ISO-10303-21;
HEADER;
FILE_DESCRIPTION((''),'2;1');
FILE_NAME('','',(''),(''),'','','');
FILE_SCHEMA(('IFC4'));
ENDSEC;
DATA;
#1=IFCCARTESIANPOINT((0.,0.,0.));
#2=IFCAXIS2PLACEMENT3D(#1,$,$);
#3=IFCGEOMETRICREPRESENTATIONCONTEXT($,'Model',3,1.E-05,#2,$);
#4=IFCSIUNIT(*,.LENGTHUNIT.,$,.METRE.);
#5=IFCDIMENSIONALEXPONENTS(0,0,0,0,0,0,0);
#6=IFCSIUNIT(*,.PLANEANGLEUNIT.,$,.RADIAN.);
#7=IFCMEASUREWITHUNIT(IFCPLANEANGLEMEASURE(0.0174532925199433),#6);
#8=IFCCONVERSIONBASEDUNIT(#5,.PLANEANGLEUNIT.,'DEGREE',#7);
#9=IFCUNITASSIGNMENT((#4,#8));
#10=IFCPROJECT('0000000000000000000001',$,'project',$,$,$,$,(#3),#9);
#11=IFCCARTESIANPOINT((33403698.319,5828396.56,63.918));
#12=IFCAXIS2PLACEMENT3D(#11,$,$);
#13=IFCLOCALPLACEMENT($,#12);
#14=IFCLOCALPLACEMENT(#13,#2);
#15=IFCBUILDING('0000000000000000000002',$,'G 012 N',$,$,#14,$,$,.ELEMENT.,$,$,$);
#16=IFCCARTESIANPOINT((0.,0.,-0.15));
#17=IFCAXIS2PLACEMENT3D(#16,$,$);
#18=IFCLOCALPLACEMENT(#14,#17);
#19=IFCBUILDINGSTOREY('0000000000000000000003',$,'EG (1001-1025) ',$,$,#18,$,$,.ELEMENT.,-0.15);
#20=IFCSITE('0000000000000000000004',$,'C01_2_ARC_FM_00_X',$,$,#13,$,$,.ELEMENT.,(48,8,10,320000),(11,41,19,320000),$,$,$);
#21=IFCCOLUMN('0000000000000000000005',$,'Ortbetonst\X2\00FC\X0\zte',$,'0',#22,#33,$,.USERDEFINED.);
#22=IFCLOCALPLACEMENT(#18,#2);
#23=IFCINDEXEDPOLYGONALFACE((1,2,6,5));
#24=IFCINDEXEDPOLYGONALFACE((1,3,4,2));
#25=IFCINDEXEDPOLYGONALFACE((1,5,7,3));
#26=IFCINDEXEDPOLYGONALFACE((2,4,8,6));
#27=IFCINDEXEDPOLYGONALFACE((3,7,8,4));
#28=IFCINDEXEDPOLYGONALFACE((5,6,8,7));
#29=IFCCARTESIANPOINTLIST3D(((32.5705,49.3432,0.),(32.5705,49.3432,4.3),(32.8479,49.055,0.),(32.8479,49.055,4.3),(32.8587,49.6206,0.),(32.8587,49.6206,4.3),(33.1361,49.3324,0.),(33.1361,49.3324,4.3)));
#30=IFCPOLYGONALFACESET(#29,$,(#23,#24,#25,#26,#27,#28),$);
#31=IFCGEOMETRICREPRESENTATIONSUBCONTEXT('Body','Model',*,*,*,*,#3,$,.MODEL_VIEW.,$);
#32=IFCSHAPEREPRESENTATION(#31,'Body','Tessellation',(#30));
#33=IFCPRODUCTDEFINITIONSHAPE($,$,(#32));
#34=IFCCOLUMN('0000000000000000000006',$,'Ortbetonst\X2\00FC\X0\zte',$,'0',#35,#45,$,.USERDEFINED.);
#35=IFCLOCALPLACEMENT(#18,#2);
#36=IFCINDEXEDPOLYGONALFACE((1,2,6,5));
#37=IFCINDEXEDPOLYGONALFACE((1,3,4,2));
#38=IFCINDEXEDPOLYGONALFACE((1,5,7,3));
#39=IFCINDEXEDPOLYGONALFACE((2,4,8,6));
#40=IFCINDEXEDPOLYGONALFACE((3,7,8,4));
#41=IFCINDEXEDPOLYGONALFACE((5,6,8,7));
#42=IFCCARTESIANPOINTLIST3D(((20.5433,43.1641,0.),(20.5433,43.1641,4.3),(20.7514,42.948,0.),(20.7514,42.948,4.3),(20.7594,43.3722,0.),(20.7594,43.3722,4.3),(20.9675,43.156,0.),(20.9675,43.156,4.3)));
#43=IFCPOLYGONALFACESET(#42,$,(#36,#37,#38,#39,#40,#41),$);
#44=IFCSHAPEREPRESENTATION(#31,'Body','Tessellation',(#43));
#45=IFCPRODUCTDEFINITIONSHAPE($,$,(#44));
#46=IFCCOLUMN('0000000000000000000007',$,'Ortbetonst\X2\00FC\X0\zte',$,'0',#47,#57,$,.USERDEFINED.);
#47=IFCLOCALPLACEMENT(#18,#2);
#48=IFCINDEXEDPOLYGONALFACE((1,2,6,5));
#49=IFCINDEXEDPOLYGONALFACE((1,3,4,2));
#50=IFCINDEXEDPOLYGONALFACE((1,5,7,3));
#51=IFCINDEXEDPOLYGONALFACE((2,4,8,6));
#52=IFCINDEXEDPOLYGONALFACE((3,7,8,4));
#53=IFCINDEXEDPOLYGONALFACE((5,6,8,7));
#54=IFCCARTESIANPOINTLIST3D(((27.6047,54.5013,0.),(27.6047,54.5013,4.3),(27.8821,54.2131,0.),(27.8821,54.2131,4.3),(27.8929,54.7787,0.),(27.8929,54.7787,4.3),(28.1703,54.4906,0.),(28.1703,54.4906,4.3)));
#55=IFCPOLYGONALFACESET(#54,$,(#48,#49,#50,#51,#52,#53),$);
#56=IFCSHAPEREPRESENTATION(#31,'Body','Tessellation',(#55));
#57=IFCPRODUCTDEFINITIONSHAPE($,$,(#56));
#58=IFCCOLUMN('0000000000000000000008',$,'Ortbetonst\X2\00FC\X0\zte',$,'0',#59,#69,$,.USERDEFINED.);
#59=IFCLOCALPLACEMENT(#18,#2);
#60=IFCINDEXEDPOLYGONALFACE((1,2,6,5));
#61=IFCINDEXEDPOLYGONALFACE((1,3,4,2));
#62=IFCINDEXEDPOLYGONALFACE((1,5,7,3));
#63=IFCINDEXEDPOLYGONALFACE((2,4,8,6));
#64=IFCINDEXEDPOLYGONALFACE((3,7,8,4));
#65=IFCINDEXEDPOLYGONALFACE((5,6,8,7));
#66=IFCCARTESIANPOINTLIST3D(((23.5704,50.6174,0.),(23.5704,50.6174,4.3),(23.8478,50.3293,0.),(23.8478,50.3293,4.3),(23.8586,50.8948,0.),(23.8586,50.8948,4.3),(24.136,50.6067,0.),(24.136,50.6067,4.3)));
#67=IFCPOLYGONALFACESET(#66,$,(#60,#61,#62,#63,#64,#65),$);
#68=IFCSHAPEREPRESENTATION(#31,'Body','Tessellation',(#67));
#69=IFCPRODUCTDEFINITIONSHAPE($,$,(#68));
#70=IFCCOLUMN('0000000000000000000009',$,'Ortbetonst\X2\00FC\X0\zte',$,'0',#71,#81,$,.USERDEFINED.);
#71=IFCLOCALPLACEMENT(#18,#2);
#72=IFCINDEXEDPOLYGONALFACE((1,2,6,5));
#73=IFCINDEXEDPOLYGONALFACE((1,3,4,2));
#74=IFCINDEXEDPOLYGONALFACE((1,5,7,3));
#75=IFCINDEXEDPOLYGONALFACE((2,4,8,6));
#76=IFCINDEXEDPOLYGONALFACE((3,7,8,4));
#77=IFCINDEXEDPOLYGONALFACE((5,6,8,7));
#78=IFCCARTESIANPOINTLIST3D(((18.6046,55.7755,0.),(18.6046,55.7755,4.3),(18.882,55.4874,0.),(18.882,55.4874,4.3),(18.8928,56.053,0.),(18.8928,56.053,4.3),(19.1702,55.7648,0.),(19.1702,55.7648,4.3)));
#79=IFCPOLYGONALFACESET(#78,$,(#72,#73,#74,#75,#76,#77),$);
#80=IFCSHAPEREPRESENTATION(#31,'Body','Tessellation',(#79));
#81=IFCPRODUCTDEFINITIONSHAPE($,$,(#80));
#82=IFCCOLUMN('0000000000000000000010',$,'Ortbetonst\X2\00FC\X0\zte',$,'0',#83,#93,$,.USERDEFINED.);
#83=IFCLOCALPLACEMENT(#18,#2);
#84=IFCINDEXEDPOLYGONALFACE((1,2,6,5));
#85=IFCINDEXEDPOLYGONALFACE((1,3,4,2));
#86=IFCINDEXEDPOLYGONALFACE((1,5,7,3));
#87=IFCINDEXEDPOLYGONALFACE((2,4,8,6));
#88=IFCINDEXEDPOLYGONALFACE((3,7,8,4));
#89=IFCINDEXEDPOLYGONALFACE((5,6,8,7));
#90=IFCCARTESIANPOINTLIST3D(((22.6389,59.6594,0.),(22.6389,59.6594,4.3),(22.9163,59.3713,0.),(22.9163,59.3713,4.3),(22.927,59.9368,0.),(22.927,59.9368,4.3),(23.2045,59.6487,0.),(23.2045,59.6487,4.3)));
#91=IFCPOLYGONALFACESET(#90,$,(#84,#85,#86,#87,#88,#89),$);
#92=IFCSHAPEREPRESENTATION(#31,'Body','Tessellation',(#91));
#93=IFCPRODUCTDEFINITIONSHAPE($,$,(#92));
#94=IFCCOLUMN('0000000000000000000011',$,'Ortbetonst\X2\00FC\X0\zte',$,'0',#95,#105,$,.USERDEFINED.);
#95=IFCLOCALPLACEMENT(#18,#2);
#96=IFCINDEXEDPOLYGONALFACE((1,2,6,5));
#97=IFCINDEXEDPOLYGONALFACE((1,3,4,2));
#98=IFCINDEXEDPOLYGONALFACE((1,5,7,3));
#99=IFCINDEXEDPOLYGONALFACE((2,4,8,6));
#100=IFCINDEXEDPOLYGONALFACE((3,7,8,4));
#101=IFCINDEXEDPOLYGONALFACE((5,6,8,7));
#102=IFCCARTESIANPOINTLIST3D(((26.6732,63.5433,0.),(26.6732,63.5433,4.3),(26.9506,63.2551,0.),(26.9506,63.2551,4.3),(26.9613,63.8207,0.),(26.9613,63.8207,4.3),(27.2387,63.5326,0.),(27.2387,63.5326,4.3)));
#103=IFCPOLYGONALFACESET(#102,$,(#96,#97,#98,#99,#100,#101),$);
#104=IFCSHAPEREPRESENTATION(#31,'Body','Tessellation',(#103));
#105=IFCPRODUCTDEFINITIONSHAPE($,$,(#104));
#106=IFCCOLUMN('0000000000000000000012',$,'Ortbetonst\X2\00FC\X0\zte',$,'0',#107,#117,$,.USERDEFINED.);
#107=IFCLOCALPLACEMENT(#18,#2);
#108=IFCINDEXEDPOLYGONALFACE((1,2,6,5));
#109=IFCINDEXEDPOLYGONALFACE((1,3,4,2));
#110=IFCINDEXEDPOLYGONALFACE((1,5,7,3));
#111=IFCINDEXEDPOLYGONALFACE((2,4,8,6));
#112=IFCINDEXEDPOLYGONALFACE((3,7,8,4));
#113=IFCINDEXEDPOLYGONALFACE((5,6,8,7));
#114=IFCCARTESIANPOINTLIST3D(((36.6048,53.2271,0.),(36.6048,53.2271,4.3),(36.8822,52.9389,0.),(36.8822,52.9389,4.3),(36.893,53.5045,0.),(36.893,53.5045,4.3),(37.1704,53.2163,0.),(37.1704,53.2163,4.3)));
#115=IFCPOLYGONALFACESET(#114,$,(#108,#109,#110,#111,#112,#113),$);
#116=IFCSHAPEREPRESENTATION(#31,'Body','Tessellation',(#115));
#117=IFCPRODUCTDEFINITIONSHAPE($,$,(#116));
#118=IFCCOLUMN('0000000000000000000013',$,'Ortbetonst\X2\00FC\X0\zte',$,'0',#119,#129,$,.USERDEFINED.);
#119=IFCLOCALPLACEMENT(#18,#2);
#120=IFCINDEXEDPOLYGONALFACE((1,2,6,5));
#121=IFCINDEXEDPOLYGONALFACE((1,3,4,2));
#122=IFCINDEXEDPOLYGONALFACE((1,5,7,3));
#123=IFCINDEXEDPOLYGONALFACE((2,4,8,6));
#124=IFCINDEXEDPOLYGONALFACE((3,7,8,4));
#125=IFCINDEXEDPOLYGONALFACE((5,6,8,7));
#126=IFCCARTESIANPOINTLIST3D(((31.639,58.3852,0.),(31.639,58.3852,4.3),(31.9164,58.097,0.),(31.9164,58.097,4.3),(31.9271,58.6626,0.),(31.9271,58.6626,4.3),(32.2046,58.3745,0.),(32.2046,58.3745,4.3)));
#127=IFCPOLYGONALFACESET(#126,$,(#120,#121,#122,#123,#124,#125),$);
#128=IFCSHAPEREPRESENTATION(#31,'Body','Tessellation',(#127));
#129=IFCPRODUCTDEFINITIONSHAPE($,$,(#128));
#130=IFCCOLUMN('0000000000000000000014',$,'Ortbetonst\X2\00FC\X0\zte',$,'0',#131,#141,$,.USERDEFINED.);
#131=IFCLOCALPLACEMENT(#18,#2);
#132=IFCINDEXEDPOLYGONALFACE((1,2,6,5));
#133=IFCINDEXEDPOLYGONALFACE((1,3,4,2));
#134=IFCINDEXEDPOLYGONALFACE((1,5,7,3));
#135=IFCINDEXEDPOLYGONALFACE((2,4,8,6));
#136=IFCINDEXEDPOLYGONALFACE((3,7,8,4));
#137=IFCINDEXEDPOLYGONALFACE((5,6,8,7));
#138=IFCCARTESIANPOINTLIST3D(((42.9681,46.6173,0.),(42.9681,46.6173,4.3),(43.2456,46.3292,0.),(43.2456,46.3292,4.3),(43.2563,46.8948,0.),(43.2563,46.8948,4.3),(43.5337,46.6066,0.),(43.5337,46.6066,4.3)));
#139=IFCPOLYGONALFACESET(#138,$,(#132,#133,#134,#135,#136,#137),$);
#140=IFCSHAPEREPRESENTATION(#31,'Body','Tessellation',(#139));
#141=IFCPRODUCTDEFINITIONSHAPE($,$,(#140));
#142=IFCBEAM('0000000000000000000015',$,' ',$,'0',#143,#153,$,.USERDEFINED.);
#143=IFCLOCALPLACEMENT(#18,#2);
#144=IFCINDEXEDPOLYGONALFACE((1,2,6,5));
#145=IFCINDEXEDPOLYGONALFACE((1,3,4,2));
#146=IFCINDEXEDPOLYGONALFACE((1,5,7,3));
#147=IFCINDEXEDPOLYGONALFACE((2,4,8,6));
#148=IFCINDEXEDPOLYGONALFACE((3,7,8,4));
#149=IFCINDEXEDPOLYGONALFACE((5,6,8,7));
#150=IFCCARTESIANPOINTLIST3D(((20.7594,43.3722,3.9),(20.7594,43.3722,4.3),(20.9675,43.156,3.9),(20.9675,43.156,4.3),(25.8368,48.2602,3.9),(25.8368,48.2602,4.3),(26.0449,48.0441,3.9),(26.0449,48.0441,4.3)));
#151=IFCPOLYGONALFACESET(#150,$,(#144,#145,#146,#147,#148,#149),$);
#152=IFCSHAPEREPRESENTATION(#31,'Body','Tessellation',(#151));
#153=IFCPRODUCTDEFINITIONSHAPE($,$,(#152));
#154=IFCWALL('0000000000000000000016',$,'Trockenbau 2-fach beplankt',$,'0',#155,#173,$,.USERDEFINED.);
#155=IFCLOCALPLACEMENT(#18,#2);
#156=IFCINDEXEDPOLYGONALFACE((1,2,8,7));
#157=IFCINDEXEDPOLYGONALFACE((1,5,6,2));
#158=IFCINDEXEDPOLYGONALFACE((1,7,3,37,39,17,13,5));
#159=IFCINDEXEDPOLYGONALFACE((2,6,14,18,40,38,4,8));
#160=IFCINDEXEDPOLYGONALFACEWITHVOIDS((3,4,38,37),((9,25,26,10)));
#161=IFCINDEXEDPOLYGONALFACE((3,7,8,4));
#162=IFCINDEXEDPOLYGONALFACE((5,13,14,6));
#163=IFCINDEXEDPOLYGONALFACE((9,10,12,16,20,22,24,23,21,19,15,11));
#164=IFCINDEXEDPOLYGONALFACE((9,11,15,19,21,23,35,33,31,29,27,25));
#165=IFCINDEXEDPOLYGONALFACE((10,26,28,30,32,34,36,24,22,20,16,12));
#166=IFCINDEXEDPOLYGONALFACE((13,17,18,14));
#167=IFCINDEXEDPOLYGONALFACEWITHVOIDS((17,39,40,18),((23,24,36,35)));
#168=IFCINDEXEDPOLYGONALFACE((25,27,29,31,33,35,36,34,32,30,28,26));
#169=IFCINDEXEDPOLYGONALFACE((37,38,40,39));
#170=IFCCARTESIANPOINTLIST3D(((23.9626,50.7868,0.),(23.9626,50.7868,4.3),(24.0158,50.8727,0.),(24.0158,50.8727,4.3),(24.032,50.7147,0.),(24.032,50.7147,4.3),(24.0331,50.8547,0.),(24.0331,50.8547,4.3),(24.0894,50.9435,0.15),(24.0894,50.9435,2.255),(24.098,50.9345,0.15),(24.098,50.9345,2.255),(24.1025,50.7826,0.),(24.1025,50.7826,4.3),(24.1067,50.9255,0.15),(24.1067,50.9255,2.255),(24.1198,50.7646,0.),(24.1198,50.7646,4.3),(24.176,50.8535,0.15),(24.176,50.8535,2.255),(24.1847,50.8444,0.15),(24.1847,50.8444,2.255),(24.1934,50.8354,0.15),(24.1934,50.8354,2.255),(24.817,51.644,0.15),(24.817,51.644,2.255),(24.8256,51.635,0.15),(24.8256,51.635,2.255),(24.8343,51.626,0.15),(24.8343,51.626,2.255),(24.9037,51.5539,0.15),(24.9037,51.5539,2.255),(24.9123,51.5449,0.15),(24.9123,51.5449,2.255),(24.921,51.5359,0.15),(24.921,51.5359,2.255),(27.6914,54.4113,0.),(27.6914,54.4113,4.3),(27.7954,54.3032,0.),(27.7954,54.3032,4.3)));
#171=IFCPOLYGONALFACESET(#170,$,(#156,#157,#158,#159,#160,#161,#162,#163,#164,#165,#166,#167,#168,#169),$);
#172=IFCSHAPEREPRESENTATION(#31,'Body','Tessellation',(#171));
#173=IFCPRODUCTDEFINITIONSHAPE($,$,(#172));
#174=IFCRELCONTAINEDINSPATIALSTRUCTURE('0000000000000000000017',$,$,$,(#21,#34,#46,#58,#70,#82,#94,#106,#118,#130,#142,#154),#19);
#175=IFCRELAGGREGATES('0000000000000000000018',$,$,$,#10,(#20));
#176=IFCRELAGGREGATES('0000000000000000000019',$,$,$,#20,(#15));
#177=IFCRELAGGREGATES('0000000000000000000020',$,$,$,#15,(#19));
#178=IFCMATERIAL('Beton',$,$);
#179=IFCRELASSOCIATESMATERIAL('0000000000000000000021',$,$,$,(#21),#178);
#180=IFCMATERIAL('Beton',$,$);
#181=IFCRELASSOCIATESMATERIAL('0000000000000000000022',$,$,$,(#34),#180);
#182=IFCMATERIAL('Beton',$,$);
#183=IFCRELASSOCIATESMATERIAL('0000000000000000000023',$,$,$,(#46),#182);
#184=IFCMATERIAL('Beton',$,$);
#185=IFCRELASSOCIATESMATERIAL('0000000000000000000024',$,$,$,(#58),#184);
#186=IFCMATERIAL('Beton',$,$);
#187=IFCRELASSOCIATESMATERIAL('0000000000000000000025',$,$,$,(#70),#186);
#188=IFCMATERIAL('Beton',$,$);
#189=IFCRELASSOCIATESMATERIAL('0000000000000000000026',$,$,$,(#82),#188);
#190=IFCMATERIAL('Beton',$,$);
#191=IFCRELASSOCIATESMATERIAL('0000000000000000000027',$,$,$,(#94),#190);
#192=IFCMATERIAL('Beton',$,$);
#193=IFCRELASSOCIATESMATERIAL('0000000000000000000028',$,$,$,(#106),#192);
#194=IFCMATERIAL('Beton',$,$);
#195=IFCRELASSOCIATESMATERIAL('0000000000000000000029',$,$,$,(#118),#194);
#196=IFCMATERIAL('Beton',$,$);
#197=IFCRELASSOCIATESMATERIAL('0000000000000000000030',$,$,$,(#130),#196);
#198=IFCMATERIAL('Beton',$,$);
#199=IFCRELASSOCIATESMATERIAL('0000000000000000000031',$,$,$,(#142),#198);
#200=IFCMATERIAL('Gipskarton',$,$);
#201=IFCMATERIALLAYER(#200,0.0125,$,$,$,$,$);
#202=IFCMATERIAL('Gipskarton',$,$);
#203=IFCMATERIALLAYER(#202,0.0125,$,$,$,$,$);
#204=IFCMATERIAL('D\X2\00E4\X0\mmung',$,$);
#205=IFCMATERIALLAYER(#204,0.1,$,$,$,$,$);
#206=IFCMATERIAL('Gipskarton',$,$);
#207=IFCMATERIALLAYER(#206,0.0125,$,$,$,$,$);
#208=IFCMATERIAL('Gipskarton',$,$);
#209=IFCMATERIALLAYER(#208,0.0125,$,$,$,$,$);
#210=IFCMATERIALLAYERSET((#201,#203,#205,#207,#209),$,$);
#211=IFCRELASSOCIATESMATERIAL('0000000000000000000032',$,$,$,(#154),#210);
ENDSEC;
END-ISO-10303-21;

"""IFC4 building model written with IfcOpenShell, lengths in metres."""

from ifc_helpers import new_model, entity, si_unit, converted_unit, frame, frame_2d, origin, origin_with_axes, place, context, subcontext, project, spatial, polyline, rectangle, outline, extrude, material, layer, layer_set, layer_usage, element, save


model = new_model("IFC4")

# Units and contexts
model_context = context("Model", 3, precision=1e-05, world=origin())
body_context = subcontext(model_context, "Body", "Model", "MODEL_VIEW")
ifc_project = project(units=[si_unit("LENGTHUNIT", "METRE"), converted_unit("PLANEANGLEUNIT", "DEGREE", entity("IfcPlaneAngleMeasure", 0.0174532925199433), si_unit("PLANEANGLEUNIT", "RADIAN"), dimensions=[0, 0, 0, 0, 0, 0, 0])], contexts=[model_context])

# Site, building, storey
site_placement = place(None, frame((33403698.319, 5828396.56, 63.918)))
site = spatial("IfcSite", under=ifc_project, at=site_placement, Name="C01_2_ARC_FM_00_X", CompositionType="ELEMENT", RefLatitude=(48, 8, 10, 320000), RefLongitude=(11, 41, 19, 320000))
building_placement = place(site_placement, origin())
building = spatial("IfcBuilding", under=site, at=building_placement, Name="G 012 N", CompositionType="ELEMENT")
storey_placement = place(building_placement, frame((0.0, 0.0, -0.15)))
storey = spatial("IfcBuildingStorey", under=building, at=storey_placement, Name="EG (1001-1025) ", CompositionType="ELEMENT", Elevation=-0.15)

# Columns
ifc_material_1 = material(Name="Beton")
column_1_placement = place(storey_placement, frame((32.8479, 49.055, 0.0)))
element("IfcColumn", 1, at=column_1_placement, inside=storey, material=ifc_material_1, Name="Ortbetonstüzte", ObjectType="0", PredefinedType="USERDEFINED", context=body_context, shape_type="SweptSolid", body=[
    extrude(rectangle(XDim=0.4, YDim=0.4, at=frame_2d((0.0054, 0.2828), x_axis=(0.720408, 0.693551))), origin_with_axes(), (0.0, 0.0, 1.0), 4.3),
])
ifc_material_2 = material(Name="Beton")
column_2_placement = place(storey_placement, frame((20.7514, 42.948, 0.0)))
element("IfcColumn", 2, at=column_2_placement, inside=storey, material=ifc_material_2, Name="Ortbetonstüzte", ObjectType="0", PredefinedType="USERDEFINED", context=body_context, shape_type="SweptSolid", body=[
    extrude(rectangle(XDim=0.3, YDim=0.3, at=frame_2d((0.004, 0.2121), x_axis=(0.720408, 0.693551))), origin_with_axes(), (0.0, 0.0, 1.0), 4.3),
])
ifc_material_3 = material(Name="Beton")
column_3_placement = place(storey_placement, frame((27.8821, 54.2131, 0.0)))
element("IfcColumn", 3, at=column_3_placement, inside=storey, material=ifc_material_3, Name="Ortbetonstüzte", ObjectType="0", PredefinedType="USERDEFINED", context=body_context, shape_type="SweptSolid", body=[
    extrude(rectangle(XDim=0.4, YDim=0.4, at=frame_2d((0.0054, 0.2828), x_axis=(0.720408, 0.693551))), origin_with_axes(), (0.0, 0.0, 1.0), 4.3),
])
ifc_material_4 = material(Name="Beton")
column_4_placement = place(storey_placement, frame((23.8478, 50.3293, 0.0)))
element("IfcColumn", 4, at=column_4_placement, inside=storey, material=ifc_material_4, Name="Ortbetonstüzte", ObjectType="0", PredefinedType="USERDEFINED", context=body_context, shape_type="SweptSolid", body=[
    extrude(rectangle(XDim=0.4, YDim=0.4, at=frame_2d((0.0054, 0.2828), x_axis=(0.720408, 0.693551))), origin_with_axes(), (0.0, 0.0, 1.0), 4.3),
])
ifc_material_5 = material(Name="Beton")
column_5_placement = place(storey_placement, frame((18.882, 55.4874, 0.0)))
element("IfcColumn", 5, at=column_5_placement, inside=storey, material=ifc_material_5, Name="Ortbetonstüzte", ObjectType="0", PredefinedType="USERDEFINED", context=body_context, shape_type="SweptSolid", body=[
    extrude(rectangle(XDim=0.4, YDim=0.4, at=frame_2d((0.0054, 0.2828), x_axis=(0.720408, 0.693551))), origin_with_axes(), (0.0, 0.0, 1.0), 4.3),
])
ifc_material_6 = material(Name="Beton")
column_6_placement = place(storey_placement, frame((22.9163, 59.3713, 0.0)))
element("IfcColumn", 6, at=column_6_placement, inside=storey, material=ifc_material_6, Name="Ortbetonstüzte", ObjectType="0", PredefinedType="USERDEFINED", context=body_context, shape_type="SweptSolid", body=[
    extrude(rectangle(XDim=0.4, YDim=0.4, at=frame_2d((0.0054, 0.2828), x_axis=(0.720408, 0.693551))), origin_with_axes(), (0.0, 0.0, 1.0), 4.3),
])
ifc_material_7 = material(Name="Beton")
column_7_placement = place(storey_placement, frame((26.9506, 63.2551, 0.0)))
element("IfcColumn", 7, at=column_7_placement, inside=storey, material=ifc_material_7, Name="Ortbetonstüzte", ObjectType="0", PredefinedType="USERDEFINED", context=body_context, shape_type="SweptSolid", body=[
    extrude(rectangle(XDim=0.4, YDim=0.4, at=frame_2d((0.0054, 0.2828), x_axis=(0.720408, 0.693551))), origin_with_axes(), (0.0, 0.0, 1.0), 4.3),
])
ifc_material_8 = material(Name="Beton")
column_8_placement = place(storey_placement, frame((36.8822, 52.9389, 0.0)))
element("IfcColumn", 8, at=column_8_placement, inside=storey, material=ifc_material_8, Name="Ortbetonstüzte", ObjectType="0", PredefinedType="USERDEFINED", context=body_context, shape_type="SweptSolid", body=[
    extrude(rectangle(XDim=0.4, YDim=0.4, at=frame_2d((0.0054, 0.2828), x_axis=(0.720408, 0.693551))), origin_with_axes(), (0.0, 0.0, 1.0), 4.3),
])
ifc_material_9 = material(Name="Beton")
column_9_placement = place(storey_placement, frame((31.9164, 58.097, 0.0)))
element("IfcColumn", 9, at=column_9_placement, inside=storey, material=ifc_material_9, Name="Ortbetonstüzte", ObjectType="0", PredefinedType="USERDEFINED", context=body_context, shape_type="SweptSolid", body=[
    extrude(rectangle(XDim=0.4, YDim=0.4, at=frame_2d((0.0054, 0.2828), x_axis=(0.720408, 0.693551))), origin_with_axes(), (0.0, 0.0, 1.0), 4.3),
])
ifc_material_10 = material(Name="Beton")
column_10_placement = place(storey_placement, frame((43.2456, 46.3292, 0.0)))
element("IfcColumn", 10, at=column_10_placement, inside=storey, material=ifc_material_10, Name="Ortbetonstüzte", ObjectType="0", PredefinedType="USERDEFINED", context=body_context, shape_type="SweptSolid", body=[
    extrude(rectangle(XDim=0.4, YDim=0.4, at=frame_2d((0.0054, 0.2828), x_axis=(0.720408, 0.693551))), origin_with_axes(), (0.0, 0.0, 1.0), 4.3),
])

# Beam
ifc_material_11 = material(Name="Beton")
beam_placement = place(storey_placement, frame((20.9675, 43.156, 3.9), z_axis=(0.0, 0.0, 1.0), x_axis=(0.720408, 0.693551, 0.0)))
element("IfcBeam", 11, at=beam_placement, inside=storey, material=ifc_material_11, Name=" ", ObjectType="0", PredefinedType="USERDEFINED", context=body_context, shape_type="SweptSolid", body=[
    extrude(rectangle(XDim=0.3, YDim=0.4, at=frame_2d((0.15, 0.2), x_axis=(1.0, 0.0))), frame((0.0, 0.0, 0.0), z_axis=(1.0, 0.0, 0.0), x_axis=(0.0, 1.0, 0.0)), (0.0, 0.0, 1.0), 7.0479),
])

# Wall, opening
ifc_material_12 = material(Name="Gipskarton")
ifc_layer_1 = layer(ifc_material_12, 0.0125)
ifc_material_13 = material(Name="Gipskarton")
ifc_layer_2 = layer(ifc_material_13, 0.0125)
ifc_material_14 = material(Name="Dämmung")
ifc_layer_3 = layer(ifc_material_14, 0.1)
ifc_material_15 = material(Name="Gipskarton")
ifc_layer_4 = layer(ifc_material_15, 0.0125)
ifc_material_16 = material(Name="Gipskarton")
ifc_layer_5 = layer(ifc_material_16, 0.0125)
ifc_layer_set_1 = layer_set([ifc_layer_1, ifc_layer_2, ifc_layer_3, ifc_layer_4, ifc_layer_5])
ifc_layer_usage_1 = layer_usage(ifc_layer_set_1, "AXIS2", "POSITIVE", 0.0)
wall_1_placement = place(storey_placement, frame((27.6914, 54.4113, 0.0), z_axis=(0.0, 0.0, 1.0), x_axis=(-0.720408, -0.693551, 0.0)))
wall_1 = element("IfcWall", 12, at=wall_1_placement, inside=storey, material=ifc_layer_usage_1, Name="Trockenbau 2-fach beplankt", ObjectType="0", PredefinedType="USERDEFINED", context=body_context, shape_type="SweptSolid", body=[
    extrude(outline(polyline([(-5.25, -0.0769), (-0.1478, -0.0769), (-0.1478, -0.0519), (-0.05, -0.0519), (-0.05, 0.0481), (-0.1478, 0.0481), (-0.1478, 0.0731), (-5.25, 0.0731), (-5.25, -0.0769)])), frame((5.25, 0.0769, 0.0), z_axis=(0.0, 0.0, 1.0), x_axis=(1.0, 0.0, 0.0)), (0.0, 0.0, 1.0), 4.3),
])
opening_1_placement = place(wall_1_placement, frame((5.0, 0.0125, 0.15), z_axis=(0.0, -1.0, 0.0), x_axis=(0.0, 0.0, 1.0)))
element("IfcOpeningElement", 13, at=opening_1_placement, cuts=wall_1, ObjectType="0", PredefinedType="USERDEFINED", context=body_context, shape_type="SweptSolid", body=[
    extrude(outline(polyline([(0.0, 1.01), (2.105, 1.01), (2.105, 0.0), (0.0, 0.0), (0.0, 1.01)])), origin_with_axes(), (0.0, 0.0, 1.0), 0.0125),
    extrude(outline(polyline([(0.0, 1.01), (2.105, 1.01), (2.105, 0.0), (0.0, 0.0), (0.0, 1.01)])), frame((0.0, 0.0, -0.0125), z_axis=(0.0, 0.0, 1.0), x_axis=(1.0, 0.0, 0.0)), (0.0, 0.0, 1.0), 0.0125),
    extrude(outline(polyline([(0.0, 1.01), (2.105, 1.01), (2.105, 0.0), (0.0, 0.0), (0.0, 1.01)])), frame((0.0, 0.0, -0.1125), z_axis=(0.0, 0.0, 1.0), x_axis=(1.0, 0.0, 0.0)), (0.0, 0.0, 1.0), 0.1),
    extrude(outline(polyline([(0.0, 1.01), (2.105, 1.01), (2.105, 0.0), (0.0, 0.0), (0.0, 1.01)])), frame((0.0, 0.0, -0.125), z_axis=(0.0, 0.0, 1.0), x_axis=(1.0, 0.0, 0.0)), (0.0, 0.0, 1.0), 0.0125),
    extrude(outline(polyline([(0.0, 1.01), (2.105, 1.01), (2.105, 0.0), (0.0, 0.0), (0.0, 1.01)])), frame((0.0, 0.0, -0.1375), z_axis=(0.0, 0.0, 1.0), x_axis=(1.0, 0.0, 0.0)), (0.0, 0.0, 1.0), 0.0125),
])

save(model, "model.ifc")
